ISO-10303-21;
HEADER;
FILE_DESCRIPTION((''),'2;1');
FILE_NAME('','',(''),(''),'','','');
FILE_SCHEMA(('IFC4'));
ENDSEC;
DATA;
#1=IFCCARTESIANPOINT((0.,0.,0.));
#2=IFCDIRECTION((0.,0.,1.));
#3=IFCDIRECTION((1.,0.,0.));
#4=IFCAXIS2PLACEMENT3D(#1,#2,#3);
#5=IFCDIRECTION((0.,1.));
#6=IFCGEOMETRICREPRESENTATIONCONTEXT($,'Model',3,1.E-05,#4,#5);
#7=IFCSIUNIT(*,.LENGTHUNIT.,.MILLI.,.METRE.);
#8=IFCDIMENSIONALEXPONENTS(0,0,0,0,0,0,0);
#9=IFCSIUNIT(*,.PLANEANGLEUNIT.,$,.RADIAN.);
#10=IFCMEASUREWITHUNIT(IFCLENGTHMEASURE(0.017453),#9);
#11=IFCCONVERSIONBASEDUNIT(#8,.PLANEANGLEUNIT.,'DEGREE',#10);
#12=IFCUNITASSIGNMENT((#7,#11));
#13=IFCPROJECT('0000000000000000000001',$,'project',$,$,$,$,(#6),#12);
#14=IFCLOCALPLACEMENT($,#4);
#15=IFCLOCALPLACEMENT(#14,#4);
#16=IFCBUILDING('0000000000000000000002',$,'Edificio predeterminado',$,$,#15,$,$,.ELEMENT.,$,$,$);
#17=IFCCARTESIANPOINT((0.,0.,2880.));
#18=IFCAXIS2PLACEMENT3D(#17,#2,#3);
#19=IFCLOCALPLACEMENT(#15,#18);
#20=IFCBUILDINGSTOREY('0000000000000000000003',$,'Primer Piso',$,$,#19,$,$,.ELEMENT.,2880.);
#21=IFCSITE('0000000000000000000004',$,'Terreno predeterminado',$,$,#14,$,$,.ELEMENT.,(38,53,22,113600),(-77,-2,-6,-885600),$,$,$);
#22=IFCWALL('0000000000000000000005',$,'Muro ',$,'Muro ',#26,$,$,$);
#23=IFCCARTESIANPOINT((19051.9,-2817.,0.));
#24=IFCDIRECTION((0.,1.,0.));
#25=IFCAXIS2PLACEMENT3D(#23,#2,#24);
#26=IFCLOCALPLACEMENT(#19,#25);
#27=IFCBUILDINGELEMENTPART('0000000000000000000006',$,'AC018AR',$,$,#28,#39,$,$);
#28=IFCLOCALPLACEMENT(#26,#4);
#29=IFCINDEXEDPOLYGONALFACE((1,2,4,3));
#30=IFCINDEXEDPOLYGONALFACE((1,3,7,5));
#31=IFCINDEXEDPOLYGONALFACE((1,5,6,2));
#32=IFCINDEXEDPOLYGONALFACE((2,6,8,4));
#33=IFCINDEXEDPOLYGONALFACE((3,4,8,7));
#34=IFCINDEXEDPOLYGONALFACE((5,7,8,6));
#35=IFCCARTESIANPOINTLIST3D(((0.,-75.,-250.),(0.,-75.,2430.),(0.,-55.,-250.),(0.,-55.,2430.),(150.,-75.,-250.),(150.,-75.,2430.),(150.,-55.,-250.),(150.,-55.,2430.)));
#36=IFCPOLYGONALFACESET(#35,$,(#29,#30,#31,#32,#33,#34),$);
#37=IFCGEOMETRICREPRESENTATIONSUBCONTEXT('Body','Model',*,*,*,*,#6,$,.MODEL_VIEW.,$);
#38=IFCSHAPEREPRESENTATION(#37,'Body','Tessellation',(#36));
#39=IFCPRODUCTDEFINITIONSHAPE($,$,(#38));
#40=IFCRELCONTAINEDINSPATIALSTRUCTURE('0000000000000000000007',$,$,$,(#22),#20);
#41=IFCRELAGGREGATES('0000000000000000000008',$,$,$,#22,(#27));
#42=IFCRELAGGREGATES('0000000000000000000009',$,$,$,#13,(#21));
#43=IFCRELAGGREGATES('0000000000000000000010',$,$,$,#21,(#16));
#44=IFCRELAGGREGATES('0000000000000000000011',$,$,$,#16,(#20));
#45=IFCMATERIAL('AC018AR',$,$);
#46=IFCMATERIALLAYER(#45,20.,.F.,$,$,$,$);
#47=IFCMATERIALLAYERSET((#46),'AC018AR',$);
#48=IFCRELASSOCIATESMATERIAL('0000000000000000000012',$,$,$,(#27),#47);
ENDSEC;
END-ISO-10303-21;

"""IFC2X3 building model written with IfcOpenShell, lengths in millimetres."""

from ifc_helpers import new_model, entity, si_unit, converted_unit, direction, frame, origin_with_axes, place, context, subcontext, project, spatial, polyline, outline, extrude, clip, bounded_halfspace, material, layer, layer_set, layer_usage, element, aggregate, save


model = new_model("IFC2X3")

# Units and contexts
model_context = context("Model", 3, precision=1e-05, world=origin_with_axes(), true_north=direction((0.0, 1.0)))
body_context = subcontext(model_context, "Body", "Model", "MODEL_VIEW")
ifc_project = project(units=[si_unit("LENGTHUNIT", "METRE", prefix="MILLI"), converted_unit("PLANEANGLEUNIT", "DEGREE", entity("IfcLengthMeasure", 0.017453), si_unit("PLANEANGLEUNIT", "RADIAN"), dimensions=[0, 0, 0, 0, 0, 0, 0])], contexts=[model_context])

# Site, building, storey
site_placement = place(None, origin_with_axes())
site = spatial("IfcSite", under=ifc_project, at=site_placement, Name="Terreno predeterminado", CompositionType="ELEMENT", RefLatitude=(38, 53, 22, 113600), RefLongitude=(-77, -2, -6, -885600))
building_placement = place(site_placement, origin_with_axes())
building = spatial("IfcBuilding", under=site, at=building_placement, Name="Edificio predeterminado", CompositionType="ELEMENT")
storey_placement = place(building_placement, frame((0.0, 0.0, 2880.0), z_axis=(0.0, 0.0, 1.0), x_axis=(1.0, 0.0, 0.0)))
storey = spatial("IfcBuildingStorey", under=building, at=storey_placement, Name="Primer Piso", CompositionType="ELEMENT", Elevation=2880.0)

# Wall, building element part
wall_1_placement = place(storey_placement, frame((19051.9, -2817.0, 0.0), z_axis=(0.0, 0.0, 1.0), x_axis=(0.0, 1.0, 0.0)))
wall_1 = element("IfcWall", 1, at=wall_1_placement, inside=storey, Name="Muro ", ObjectType="Muro ")
ifc_material_1 = material(Name="AC018AR")
ifc_layer_1 = layer(ifc_material_1, 20.0, ventilated=False)
ifc_layer_set_1 = layer_set([ifc_layer_1], Name="AC018AR")
ifc_layer_usage_1 = layer_usage(ifc_layer_set_1, "AXIS2", "NEGATIVE", 55.0)
building_element_part_1_placement = place(wall_1_placement, origin_with_axes())
building_element_part_1 = element("IfcBuildingElementPart", 2, at=building_element_part_1_placement, material=ifc_layer_usage_1, Name="AC018AR", context=body_context, shape_type="Clipping", body=[
    clip(clip(extrude(outline(polyline([(150.0, -55.0), (150.0, -75.0), (0.0, -75.0), (0.0, -55.0), (150.0, -55.0)])), frame((0.0, 0.0, -250.0), z_axis=(0.0, 0.0, 1.0), x_axis=(1.0, 0.0, 0.0)), (0.0, 0.0, 1.0), 2680.0), bounded_halfspace(frame((0.0, 0.0, -250.0), z_axis=(0.0, 0.0, 1.0), x_axis=(1.0, 0.0, 0.0)), True, origin_with_axes(), polyline([(-150.0, -150.0), (375.0, -150.0), (375.0, 150.0), (-150.0, 150.0), (-150.0, -150.0)]))), bounded_halfspace(frame((0.0, 0.0, 2430.0), z_axis=(0.0, 0.0, 1.0), x_axis=(1.0, 0.0, 0.0)), False, origin_with_axes(), polyline([(-150.0, -150.0), (375.0, -150.0), (375.0, 150.0), (-150.0, 150.0), (-150.0, -150.0)]))),
])
aggregate(wall_1, [building_element_part_1])

save(model, "model.ifc")
